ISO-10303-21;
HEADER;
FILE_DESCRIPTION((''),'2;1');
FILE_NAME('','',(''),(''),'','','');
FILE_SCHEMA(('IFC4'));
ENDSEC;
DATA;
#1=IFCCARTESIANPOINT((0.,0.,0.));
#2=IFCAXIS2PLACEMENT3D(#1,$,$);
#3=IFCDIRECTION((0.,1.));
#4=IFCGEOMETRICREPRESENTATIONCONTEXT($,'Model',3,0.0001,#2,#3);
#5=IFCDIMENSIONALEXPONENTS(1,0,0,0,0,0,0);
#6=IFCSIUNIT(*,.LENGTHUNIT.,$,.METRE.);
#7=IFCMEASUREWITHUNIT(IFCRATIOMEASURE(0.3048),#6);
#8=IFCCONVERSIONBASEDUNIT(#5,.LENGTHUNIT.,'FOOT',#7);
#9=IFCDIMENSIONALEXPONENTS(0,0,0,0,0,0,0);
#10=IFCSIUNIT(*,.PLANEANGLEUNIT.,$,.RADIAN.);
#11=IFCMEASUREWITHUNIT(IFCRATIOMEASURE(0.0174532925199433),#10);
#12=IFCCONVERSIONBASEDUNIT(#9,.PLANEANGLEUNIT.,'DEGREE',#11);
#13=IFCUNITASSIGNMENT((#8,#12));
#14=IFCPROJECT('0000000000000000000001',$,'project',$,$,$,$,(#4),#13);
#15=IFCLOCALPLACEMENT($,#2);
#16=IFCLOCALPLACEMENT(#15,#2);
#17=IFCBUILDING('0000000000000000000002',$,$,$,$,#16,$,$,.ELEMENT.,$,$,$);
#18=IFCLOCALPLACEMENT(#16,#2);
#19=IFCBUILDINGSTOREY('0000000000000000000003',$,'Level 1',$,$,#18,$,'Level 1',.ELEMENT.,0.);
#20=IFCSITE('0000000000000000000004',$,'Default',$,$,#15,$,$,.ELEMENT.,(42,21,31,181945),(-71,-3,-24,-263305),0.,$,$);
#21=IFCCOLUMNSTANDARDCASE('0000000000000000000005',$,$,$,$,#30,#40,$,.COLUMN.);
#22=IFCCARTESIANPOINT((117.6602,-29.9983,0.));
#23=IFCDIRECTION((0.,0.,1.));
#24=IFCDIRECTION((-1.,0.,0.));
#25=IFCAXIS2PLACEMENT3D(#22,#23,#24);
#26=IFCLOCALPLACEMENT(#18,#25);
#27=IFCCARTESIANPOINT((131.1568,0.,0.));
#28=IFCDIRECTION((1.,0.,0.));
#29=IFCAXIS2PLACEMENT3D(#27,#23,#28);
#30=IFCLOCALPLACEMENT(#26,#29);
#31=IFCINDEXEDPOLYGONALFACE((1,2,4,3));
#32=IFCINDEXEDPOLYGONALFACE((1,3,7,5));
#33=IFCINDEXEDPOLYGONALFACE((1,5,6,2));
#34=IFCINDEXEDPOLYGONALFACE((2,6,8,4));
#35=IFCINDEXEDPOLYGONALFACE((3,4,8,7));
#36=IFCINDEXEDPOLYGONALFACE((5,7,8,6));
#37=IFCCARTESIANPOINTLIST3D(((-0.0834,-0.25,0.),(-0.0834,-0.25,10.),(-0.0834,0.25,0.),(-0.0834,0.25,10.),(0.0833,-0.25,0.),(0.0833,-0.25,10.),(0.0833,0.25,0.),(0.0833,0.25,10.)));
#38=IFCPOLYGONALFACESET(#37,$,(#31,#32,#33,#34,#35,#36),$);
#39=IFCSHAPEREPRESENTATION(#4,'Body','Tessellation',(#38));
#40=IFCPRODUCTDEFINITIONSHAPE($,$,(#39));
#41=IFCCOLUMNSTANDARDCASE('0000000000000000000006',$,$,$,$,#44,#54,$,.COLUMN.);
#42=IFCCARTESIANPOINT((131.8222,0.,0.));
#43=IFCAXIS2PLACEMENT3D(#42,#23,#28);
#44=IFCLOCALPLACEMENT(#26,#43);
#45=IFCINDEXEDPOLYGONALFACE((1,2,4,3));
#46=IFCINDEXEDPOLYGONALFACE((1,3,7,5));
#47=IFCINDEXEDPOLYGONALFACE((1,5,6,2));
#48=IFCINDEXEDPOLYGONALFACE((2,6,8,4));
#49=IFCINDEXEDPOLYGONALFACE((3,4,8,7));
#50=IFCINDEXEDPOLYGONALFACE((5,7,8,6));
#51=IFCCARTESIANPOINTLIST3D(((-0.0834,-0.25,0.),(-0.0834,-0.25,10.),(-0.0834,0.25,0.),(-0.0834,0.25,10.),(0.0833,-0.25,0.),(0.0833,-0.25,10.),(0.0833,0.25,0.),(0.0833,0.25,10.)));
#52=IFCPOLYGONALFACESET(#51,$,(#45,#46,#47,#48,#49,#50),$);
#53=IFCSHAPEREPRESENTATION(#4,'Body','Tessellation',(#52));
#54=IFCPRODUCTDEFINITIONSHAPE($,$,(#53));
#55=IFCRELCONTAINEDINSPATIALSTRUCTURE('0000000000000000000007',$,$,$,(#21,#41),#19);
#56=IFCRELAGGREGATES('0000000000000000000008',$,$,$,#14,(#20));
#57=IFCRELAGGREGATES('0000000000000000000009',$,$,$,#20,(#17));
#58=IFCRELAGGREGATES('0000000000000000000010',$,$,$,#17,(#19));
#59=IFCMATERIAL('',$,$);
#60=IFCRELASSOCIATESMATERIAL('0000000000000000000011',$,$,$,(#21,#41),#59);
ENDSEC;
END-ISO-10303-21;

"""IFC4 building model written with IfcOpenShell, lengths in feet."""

from ifc_helpers import new_model, entity, si_unit, converted_unit, direction, frame, origin, place, context, project, spatial, rectangle, extrude, material, element, save


model = new_model("IFC4")

# Units and contexts
model_context = context("Model", 3, precision=0.0001, world=origin(), true_north=direction((0.0, 1.0)))
ifc_project = project(units=[converted_unit("LENGTHUNIT", "FOOT", entity("IfcRatioMeasure", 0.3048), si_unit("LENGTHUNIT", "METRE"), dimensions=[1, 0, 0, 0, 0, 0, 0]), converted_unit("PLANEANGLEUNIT", "DEGREE", entity("IfcRatioMeasure", 0.0174532925199433), si_unit("PLANEANGLEUNIT", "RADIAN"), dimensions=[0, 0, 0, 0, 0, 0, 0])], contexts=[model_context])

# Site, building, storey
site_placement = place(None, origin())
site = spatial("IfcSite", under=ifc_project, at=site_placement, Name="Default", CompositionType="ELEMENT", RefLatitude=(42, 21, 31, 181945), RefLongitude=(-71, -3, -24, -263305), RefElevation=0.0)
building_placement = place(site_placement, origin())
building = spatial("IfcBuilding", under=site, at=building_placement, CompositionType="ELEMENT")
storey_placement = place(building_placement, origin())
storey = spatial("IfcBuildingStorey", under=building, at=storey_placement, Name="Level 1", LongName="Level 1", CompositionType="ELEMENT", Elevation=0.0)

# Columns
ifc_material = material(Name="")
placement = place(storey_placement, frame((117.6602, -29.9983, 0.0), z_axis=(0.0, 0.0, 1.0), x_axis=(-1.0, 0.0, 0.0)))
for number, where, z_axis, x_axis in (
    (1, (131.1568, 0.0, 0.0), (0.0, 0.0, 1.0), (1.0, 0.0, 0.0)),
    (2, (131.8222, 0.0, 0.0), (0.0, 0.0, 1.0), (1.0, 0.0, 0.0)),
):
    element("IfcColumnStandardCase", number, at=place(placement, frame(where, z_axis=z_axis, x_axis=x_axis)), inside=storey, material=ifc_material, PredefinedType="COLUMN", context=model_context, shape_type="SweptSolid", body=[
        extrude(rectangle(XDim=0.1667, YDim=0.5), origin(), (0.0, 0.0, 1.0), 10.0),
    ])

save(model, "model.ifc")
